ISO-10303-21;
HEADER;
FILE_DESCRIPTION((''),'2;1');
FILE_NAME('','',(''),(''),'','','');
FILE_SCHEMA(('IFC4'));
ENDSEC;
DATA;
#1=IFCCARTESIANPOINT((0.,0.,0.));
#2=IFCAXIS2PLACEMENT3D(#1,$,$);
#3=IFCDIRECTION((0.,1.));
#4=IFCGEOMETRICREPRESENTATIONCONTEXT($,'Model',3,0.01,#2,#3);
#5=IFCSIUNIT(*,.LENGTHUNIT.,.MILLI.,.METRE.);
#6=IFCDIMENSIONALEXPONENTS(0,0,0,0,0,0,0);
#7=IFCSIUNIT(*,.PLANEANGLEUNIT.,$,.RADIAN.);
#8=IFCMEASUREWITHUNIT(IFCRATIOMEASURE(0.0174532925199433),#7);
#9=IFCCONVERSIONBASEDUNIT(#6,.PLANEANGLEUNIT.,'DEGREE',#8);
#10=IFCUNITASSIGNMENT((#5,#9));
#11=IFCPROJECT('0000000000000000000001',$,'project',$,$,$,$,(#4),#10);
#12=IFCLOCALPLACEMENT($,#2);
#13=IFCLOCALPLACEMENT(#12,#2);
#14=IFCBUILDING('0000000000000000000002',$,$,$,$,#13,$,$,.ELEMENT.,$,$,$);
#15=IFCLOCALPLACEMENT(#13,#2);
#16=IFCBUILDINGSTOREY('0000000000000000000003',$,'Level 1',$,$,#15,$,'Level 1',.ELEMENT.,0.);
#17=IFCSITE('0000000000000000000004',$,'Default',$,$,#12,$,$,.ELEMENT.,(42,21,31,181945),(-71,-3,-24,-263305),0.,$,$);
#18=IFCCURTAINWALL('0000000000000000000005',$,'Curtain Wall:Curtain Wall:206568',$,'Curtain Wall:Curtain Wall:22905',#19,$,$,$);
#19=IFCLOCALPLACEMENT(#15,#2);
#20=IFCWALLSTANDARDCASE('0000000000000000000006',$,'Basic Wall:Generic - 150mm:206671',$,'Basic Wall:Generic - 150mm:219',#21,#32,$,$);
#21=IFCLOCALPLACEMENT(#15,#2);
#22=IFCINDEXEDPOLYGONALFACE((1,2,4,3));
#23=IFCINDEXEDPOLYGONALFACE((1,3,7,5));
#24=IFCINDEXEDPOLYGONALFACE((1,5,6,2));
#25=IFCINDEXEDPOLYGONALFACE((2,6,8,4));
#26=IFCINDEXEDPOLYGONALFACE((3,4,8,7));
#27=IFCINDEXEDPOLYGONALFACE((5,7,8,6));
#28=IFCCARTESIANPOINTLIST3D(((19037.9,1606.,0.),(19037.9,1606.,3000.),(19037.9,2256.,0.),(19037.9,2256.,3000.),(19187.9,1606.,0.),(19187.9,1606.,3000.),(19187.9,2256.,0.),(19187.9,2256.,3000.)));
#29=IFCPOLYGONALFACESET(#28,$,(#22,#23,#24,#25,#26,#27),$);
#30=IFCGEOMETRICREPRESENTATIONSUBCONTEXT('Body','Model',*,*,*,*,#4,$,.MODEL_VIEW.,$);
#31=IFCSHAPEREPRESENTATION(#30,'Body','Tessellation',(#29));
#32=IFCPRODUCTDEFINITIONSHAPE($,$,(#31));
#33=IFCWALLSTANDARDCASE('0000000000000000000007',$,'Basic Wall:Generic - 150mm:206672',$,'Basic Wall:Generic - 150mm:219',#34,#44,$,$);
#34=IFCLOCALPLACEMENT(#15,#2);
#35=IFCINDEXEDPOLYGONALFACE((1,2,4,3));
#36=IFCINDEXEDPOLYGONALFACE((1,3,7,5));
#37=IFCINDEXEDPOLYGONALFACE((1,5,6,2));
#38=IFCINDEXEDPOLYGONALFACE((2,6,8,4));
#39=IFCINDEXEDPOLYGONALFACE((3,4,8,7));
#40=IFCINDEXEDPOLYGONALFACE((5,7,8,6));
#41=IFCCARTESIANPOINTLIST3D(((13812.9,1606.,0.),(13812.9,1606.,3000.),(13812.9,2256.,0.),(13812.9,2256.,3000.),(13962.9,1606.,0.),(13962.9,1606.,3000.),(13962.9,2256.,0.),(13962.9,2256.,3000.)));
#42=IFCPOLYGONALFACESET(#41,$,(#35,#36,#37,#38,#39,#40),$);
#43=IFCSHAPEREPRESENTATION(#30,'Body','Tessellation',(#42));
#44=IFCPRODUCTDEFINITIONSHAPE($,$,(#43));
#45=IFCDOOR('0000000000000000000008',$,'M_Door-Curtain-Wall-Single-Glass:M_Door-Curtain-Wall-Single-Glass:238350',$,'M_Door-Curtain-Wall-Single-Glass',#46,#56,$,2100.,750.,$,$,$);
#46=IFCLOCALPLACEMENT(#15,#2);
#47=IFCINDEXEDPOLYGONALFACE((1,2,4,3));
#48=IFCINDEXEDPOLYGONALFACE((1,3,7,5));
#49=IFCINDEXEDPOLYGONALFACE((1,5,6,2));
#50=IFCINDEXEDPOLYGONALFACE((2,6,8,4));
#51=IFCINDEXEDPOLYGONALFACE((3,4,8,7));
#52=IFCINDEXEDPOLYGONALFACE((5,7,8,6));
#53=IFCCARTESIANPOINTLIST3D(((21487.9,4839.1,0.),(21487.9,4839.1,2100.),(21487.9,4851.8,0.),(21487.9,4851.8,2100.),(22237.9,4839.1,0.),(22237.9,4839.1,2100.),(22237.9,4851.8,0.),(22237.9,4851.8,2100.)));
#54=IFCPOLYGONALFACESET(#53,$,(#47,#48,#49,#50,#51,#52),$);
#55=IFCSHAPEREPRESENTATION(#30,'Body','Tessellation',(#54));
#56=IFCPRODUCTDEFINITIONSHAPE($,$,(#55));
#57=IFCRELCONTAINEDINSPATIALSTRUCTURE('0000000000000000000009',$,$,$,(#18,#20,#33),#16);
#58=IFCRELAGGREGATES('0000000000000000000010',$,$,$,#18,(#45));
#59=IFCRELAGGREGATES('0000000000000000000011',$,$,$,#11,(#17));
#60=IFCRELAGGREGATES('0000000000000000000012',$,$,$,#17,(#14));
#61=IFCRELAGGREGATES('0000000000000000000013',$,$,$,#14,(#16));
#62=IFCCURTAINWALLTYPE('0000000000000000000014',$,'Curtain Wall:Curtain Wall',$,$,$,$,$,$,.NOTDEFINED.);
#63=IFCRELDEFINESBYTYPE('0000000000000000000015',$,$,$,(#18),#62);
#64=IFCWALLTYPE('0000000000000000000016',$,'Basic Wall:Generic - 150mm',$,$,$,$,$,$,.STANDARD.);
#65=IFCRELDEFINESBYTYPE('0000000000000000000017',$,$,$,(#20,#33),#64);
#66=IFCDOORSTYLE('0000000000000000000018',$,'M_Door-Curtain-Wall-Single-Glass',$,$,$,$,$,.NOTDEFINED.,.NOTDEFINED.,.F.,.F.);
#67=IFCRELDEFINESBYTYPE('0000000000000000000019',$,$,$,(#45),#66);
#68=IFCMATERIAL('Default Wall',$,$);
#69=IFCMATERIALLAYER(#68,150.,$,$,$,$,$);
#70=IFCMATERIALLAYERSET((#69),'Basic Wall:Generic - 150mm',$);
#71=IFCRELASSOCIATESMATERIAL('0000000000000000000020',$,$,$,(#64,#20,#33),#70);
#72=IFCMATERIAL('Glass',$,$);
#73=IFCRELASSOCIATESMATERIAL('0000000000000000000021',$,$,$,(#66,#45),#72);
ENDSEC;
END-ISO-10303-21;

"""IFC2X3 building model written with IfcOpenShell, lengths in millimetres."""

from ifc_helpers import new_model, entity, si_unit, converted_unit, direction, frame, frame_2d, origin, place, context, subcontext, project, spatial, rectangle, extrude, source, transform, mapped, material, layer, layer_set, layer_usage, type_object, type_shapes, element, aggregate, save


model = new_model("IFC2X3")

# Units and contexts
model_context = context("Model", 3, precision=0.01, world=origin(), true_north=direction((0.0, 1.0)))
body_context = subcontext(model_context, "Body", "Model", "MODEL_VIEW")
ifc_project = project(units=[si_unit("LENGTHUNIT", "METRE", prefix="MILLI"), converted_unit("PLANEANGLEUNIT", "DEGREE", entity("IfcRatioMeasure", 0.0174532925199433), si_unit("PLANEANGLEUNIT", "RADIAN"), dimensions=[0, 0, 0, 0, 0, 0, 0])], contexts=[model_context])

# Site, building, storey
site_placement = place(None, origin())
site = spatial("IfcSite", under=ifc_project, at=site_placement, Name="Default", CompositionType="ELEMENT", RefLatitude=(42, 21, 31, 181945), RefLongitude=(-71, -3, -24, -263305), RefElevation=0.0)
building_placement = place(site_placement, origin())
building = spatial("IfcBuilding", under=site, at=building_placement, CompositionType="ELEMENT")
storey_placement = place(building_placement, origin())
storey = spatial("IfcBuildingStorey", under=building, at=storey_placement, Name="Level 1", LongName="Level 1", CompositionType="ELEMENT", Elevation=0.0)

# Shared definitions
curtain_wall_type = type_object("IfcCurtainWallType", Name="Curtain Wall:Curtain Wall", PredefinedType="NOTDEFINED")
ifc_material_1 = material(Name="Glass")

# Curtain wall
curtain_wall_1_placement = place(storey_placement, origin())
curtain_wall_1 = element("IfcCurtainWall", 1, at=curtain_wall_1_placement, inside=storey, type_object=curtain_wall_type, Name="Curtain Wall:Curtain Wall:206568", ObjectType="Curtain Wall:Curtain Wall:22905")

# Shared definitions
ifc_material_2 = material(Name="Default Wall")
ifc_layer = layer(ifc_material_2, 150.0)
ifc_layer_set = layer_set([ifc_layer], Name="Basic Wall:Generic - 150mm")
wall_type = type_object("IfcWallType", Name="Basic Wall:Generic - 150mm", PredefinedType="STANDARD", material=ifc_layer_set)

# Walls
ifc_layer_usage_1 = layer_usage(ifc_layer_set, "AXIS2", "NEGATIVE", 75.0)
wall_1_placement = place(storey_placement, frame((19112.9, 2256.0, 0.0), z_axis=(0.0, 0.0, 1.0), x_axis=(0.0, -1.0, 0.0)))
element("IfcWallStandardCase", 2, at=wall_1_placement, inside=storey, type_object=wall_type, material=ifc_layer_usage_1, Name="Basic Wall:Generic - 150mm:206671", ObjectType="Basic Wall:Generic - 150mm:219", context=body_context, shape_type="SweptSolid", body=[
    extrude(rectangle(XDim=650.0, YDim=150.0, at=frame_2d((325.0, 0.0), x_axis=(-1.0, 0.0))), origin(), (0.0, 0.0, 1.0), 3000.0),
])
ifc_layer_usage_2 = layer_usage(ifc_layer_set, "AXIS2", "NEGATIVE", 75.0)
wall_2_placement = place(storey_placement, frame((13887.9, 1606.0, 0.0), z_axis=(0.0, 0.0, 1.0), x_axis=(0.0, 1.0, 0.0)))
element("IfcWallStandardCase", 3, at=wall_2_placement, inside=storey, type_object=wall_type, material=ifc_layer_usage_2, Name="Basic Wall:Generic - 150mm:206672", ObjectType="Basic Wall:Generic - 150mm:219", context=body_context, shape_type="SweptSolid", body=[
    extrude(rectangle(XDim=650.0, YDim=150.0, at=frame_2d((325.0, 0.0), x_axis=(-1.0, 0.0))), origin(), (0.0, 0.0, 1.0), 3000.0),
])

# Door
door_style_1 = type_object("IfcDoorStyle", Name="M_Door-Curtain-Wall-Single-Glass", ConstructionType="NOTDEFINED", OperationType="NOTDEFINED", ParameterTakesPrecedence=False, Sizeable=False, material=ifc_material_1)
shared_shape_1 = source(origin(), body_context, "Body", "SweptSolid", [
    extrude(rectangle(XDim=750.0, YDim=12.7, at=frame_2d((0.0, 0.0), x_axis=(1.0, 0.0))), frame((0.0, 44.5, 0.0), z_axis=(0.0, 0.0, 1.0), x_axis=(-1.0, 0.0, 0.0)), (0.0, 0.0, 1.0), 2100.0),
])
type_shapes(door_style_1, [shared_shape_1])
door_1_placement = place(curtain_wall_1_placement, frame((21862.9, 4801.0, 0.0)))
door_1 = element("IfcDoor", 4, at=door_1_placement, type_object=door_style_1, material=ifc_material_1, Name="M_Door-Curtain-Wall-Single-Glass:M_Door-Curtain-Wall-Single-Glass:238350", ObjectType="M_Door-Curtain-Wall-Single-Glass", OverallHeight=2100.0, OverallWidth=750.0, context=body_context, shape_type="MappedRepresentation", body=[
    mapped(shared_shape_1, transform((0.0, 0.0, 0.0), scale=1.0)),
])
aggregate(curtain_wall_1, [door_1])

save(model, "model.ifc")
